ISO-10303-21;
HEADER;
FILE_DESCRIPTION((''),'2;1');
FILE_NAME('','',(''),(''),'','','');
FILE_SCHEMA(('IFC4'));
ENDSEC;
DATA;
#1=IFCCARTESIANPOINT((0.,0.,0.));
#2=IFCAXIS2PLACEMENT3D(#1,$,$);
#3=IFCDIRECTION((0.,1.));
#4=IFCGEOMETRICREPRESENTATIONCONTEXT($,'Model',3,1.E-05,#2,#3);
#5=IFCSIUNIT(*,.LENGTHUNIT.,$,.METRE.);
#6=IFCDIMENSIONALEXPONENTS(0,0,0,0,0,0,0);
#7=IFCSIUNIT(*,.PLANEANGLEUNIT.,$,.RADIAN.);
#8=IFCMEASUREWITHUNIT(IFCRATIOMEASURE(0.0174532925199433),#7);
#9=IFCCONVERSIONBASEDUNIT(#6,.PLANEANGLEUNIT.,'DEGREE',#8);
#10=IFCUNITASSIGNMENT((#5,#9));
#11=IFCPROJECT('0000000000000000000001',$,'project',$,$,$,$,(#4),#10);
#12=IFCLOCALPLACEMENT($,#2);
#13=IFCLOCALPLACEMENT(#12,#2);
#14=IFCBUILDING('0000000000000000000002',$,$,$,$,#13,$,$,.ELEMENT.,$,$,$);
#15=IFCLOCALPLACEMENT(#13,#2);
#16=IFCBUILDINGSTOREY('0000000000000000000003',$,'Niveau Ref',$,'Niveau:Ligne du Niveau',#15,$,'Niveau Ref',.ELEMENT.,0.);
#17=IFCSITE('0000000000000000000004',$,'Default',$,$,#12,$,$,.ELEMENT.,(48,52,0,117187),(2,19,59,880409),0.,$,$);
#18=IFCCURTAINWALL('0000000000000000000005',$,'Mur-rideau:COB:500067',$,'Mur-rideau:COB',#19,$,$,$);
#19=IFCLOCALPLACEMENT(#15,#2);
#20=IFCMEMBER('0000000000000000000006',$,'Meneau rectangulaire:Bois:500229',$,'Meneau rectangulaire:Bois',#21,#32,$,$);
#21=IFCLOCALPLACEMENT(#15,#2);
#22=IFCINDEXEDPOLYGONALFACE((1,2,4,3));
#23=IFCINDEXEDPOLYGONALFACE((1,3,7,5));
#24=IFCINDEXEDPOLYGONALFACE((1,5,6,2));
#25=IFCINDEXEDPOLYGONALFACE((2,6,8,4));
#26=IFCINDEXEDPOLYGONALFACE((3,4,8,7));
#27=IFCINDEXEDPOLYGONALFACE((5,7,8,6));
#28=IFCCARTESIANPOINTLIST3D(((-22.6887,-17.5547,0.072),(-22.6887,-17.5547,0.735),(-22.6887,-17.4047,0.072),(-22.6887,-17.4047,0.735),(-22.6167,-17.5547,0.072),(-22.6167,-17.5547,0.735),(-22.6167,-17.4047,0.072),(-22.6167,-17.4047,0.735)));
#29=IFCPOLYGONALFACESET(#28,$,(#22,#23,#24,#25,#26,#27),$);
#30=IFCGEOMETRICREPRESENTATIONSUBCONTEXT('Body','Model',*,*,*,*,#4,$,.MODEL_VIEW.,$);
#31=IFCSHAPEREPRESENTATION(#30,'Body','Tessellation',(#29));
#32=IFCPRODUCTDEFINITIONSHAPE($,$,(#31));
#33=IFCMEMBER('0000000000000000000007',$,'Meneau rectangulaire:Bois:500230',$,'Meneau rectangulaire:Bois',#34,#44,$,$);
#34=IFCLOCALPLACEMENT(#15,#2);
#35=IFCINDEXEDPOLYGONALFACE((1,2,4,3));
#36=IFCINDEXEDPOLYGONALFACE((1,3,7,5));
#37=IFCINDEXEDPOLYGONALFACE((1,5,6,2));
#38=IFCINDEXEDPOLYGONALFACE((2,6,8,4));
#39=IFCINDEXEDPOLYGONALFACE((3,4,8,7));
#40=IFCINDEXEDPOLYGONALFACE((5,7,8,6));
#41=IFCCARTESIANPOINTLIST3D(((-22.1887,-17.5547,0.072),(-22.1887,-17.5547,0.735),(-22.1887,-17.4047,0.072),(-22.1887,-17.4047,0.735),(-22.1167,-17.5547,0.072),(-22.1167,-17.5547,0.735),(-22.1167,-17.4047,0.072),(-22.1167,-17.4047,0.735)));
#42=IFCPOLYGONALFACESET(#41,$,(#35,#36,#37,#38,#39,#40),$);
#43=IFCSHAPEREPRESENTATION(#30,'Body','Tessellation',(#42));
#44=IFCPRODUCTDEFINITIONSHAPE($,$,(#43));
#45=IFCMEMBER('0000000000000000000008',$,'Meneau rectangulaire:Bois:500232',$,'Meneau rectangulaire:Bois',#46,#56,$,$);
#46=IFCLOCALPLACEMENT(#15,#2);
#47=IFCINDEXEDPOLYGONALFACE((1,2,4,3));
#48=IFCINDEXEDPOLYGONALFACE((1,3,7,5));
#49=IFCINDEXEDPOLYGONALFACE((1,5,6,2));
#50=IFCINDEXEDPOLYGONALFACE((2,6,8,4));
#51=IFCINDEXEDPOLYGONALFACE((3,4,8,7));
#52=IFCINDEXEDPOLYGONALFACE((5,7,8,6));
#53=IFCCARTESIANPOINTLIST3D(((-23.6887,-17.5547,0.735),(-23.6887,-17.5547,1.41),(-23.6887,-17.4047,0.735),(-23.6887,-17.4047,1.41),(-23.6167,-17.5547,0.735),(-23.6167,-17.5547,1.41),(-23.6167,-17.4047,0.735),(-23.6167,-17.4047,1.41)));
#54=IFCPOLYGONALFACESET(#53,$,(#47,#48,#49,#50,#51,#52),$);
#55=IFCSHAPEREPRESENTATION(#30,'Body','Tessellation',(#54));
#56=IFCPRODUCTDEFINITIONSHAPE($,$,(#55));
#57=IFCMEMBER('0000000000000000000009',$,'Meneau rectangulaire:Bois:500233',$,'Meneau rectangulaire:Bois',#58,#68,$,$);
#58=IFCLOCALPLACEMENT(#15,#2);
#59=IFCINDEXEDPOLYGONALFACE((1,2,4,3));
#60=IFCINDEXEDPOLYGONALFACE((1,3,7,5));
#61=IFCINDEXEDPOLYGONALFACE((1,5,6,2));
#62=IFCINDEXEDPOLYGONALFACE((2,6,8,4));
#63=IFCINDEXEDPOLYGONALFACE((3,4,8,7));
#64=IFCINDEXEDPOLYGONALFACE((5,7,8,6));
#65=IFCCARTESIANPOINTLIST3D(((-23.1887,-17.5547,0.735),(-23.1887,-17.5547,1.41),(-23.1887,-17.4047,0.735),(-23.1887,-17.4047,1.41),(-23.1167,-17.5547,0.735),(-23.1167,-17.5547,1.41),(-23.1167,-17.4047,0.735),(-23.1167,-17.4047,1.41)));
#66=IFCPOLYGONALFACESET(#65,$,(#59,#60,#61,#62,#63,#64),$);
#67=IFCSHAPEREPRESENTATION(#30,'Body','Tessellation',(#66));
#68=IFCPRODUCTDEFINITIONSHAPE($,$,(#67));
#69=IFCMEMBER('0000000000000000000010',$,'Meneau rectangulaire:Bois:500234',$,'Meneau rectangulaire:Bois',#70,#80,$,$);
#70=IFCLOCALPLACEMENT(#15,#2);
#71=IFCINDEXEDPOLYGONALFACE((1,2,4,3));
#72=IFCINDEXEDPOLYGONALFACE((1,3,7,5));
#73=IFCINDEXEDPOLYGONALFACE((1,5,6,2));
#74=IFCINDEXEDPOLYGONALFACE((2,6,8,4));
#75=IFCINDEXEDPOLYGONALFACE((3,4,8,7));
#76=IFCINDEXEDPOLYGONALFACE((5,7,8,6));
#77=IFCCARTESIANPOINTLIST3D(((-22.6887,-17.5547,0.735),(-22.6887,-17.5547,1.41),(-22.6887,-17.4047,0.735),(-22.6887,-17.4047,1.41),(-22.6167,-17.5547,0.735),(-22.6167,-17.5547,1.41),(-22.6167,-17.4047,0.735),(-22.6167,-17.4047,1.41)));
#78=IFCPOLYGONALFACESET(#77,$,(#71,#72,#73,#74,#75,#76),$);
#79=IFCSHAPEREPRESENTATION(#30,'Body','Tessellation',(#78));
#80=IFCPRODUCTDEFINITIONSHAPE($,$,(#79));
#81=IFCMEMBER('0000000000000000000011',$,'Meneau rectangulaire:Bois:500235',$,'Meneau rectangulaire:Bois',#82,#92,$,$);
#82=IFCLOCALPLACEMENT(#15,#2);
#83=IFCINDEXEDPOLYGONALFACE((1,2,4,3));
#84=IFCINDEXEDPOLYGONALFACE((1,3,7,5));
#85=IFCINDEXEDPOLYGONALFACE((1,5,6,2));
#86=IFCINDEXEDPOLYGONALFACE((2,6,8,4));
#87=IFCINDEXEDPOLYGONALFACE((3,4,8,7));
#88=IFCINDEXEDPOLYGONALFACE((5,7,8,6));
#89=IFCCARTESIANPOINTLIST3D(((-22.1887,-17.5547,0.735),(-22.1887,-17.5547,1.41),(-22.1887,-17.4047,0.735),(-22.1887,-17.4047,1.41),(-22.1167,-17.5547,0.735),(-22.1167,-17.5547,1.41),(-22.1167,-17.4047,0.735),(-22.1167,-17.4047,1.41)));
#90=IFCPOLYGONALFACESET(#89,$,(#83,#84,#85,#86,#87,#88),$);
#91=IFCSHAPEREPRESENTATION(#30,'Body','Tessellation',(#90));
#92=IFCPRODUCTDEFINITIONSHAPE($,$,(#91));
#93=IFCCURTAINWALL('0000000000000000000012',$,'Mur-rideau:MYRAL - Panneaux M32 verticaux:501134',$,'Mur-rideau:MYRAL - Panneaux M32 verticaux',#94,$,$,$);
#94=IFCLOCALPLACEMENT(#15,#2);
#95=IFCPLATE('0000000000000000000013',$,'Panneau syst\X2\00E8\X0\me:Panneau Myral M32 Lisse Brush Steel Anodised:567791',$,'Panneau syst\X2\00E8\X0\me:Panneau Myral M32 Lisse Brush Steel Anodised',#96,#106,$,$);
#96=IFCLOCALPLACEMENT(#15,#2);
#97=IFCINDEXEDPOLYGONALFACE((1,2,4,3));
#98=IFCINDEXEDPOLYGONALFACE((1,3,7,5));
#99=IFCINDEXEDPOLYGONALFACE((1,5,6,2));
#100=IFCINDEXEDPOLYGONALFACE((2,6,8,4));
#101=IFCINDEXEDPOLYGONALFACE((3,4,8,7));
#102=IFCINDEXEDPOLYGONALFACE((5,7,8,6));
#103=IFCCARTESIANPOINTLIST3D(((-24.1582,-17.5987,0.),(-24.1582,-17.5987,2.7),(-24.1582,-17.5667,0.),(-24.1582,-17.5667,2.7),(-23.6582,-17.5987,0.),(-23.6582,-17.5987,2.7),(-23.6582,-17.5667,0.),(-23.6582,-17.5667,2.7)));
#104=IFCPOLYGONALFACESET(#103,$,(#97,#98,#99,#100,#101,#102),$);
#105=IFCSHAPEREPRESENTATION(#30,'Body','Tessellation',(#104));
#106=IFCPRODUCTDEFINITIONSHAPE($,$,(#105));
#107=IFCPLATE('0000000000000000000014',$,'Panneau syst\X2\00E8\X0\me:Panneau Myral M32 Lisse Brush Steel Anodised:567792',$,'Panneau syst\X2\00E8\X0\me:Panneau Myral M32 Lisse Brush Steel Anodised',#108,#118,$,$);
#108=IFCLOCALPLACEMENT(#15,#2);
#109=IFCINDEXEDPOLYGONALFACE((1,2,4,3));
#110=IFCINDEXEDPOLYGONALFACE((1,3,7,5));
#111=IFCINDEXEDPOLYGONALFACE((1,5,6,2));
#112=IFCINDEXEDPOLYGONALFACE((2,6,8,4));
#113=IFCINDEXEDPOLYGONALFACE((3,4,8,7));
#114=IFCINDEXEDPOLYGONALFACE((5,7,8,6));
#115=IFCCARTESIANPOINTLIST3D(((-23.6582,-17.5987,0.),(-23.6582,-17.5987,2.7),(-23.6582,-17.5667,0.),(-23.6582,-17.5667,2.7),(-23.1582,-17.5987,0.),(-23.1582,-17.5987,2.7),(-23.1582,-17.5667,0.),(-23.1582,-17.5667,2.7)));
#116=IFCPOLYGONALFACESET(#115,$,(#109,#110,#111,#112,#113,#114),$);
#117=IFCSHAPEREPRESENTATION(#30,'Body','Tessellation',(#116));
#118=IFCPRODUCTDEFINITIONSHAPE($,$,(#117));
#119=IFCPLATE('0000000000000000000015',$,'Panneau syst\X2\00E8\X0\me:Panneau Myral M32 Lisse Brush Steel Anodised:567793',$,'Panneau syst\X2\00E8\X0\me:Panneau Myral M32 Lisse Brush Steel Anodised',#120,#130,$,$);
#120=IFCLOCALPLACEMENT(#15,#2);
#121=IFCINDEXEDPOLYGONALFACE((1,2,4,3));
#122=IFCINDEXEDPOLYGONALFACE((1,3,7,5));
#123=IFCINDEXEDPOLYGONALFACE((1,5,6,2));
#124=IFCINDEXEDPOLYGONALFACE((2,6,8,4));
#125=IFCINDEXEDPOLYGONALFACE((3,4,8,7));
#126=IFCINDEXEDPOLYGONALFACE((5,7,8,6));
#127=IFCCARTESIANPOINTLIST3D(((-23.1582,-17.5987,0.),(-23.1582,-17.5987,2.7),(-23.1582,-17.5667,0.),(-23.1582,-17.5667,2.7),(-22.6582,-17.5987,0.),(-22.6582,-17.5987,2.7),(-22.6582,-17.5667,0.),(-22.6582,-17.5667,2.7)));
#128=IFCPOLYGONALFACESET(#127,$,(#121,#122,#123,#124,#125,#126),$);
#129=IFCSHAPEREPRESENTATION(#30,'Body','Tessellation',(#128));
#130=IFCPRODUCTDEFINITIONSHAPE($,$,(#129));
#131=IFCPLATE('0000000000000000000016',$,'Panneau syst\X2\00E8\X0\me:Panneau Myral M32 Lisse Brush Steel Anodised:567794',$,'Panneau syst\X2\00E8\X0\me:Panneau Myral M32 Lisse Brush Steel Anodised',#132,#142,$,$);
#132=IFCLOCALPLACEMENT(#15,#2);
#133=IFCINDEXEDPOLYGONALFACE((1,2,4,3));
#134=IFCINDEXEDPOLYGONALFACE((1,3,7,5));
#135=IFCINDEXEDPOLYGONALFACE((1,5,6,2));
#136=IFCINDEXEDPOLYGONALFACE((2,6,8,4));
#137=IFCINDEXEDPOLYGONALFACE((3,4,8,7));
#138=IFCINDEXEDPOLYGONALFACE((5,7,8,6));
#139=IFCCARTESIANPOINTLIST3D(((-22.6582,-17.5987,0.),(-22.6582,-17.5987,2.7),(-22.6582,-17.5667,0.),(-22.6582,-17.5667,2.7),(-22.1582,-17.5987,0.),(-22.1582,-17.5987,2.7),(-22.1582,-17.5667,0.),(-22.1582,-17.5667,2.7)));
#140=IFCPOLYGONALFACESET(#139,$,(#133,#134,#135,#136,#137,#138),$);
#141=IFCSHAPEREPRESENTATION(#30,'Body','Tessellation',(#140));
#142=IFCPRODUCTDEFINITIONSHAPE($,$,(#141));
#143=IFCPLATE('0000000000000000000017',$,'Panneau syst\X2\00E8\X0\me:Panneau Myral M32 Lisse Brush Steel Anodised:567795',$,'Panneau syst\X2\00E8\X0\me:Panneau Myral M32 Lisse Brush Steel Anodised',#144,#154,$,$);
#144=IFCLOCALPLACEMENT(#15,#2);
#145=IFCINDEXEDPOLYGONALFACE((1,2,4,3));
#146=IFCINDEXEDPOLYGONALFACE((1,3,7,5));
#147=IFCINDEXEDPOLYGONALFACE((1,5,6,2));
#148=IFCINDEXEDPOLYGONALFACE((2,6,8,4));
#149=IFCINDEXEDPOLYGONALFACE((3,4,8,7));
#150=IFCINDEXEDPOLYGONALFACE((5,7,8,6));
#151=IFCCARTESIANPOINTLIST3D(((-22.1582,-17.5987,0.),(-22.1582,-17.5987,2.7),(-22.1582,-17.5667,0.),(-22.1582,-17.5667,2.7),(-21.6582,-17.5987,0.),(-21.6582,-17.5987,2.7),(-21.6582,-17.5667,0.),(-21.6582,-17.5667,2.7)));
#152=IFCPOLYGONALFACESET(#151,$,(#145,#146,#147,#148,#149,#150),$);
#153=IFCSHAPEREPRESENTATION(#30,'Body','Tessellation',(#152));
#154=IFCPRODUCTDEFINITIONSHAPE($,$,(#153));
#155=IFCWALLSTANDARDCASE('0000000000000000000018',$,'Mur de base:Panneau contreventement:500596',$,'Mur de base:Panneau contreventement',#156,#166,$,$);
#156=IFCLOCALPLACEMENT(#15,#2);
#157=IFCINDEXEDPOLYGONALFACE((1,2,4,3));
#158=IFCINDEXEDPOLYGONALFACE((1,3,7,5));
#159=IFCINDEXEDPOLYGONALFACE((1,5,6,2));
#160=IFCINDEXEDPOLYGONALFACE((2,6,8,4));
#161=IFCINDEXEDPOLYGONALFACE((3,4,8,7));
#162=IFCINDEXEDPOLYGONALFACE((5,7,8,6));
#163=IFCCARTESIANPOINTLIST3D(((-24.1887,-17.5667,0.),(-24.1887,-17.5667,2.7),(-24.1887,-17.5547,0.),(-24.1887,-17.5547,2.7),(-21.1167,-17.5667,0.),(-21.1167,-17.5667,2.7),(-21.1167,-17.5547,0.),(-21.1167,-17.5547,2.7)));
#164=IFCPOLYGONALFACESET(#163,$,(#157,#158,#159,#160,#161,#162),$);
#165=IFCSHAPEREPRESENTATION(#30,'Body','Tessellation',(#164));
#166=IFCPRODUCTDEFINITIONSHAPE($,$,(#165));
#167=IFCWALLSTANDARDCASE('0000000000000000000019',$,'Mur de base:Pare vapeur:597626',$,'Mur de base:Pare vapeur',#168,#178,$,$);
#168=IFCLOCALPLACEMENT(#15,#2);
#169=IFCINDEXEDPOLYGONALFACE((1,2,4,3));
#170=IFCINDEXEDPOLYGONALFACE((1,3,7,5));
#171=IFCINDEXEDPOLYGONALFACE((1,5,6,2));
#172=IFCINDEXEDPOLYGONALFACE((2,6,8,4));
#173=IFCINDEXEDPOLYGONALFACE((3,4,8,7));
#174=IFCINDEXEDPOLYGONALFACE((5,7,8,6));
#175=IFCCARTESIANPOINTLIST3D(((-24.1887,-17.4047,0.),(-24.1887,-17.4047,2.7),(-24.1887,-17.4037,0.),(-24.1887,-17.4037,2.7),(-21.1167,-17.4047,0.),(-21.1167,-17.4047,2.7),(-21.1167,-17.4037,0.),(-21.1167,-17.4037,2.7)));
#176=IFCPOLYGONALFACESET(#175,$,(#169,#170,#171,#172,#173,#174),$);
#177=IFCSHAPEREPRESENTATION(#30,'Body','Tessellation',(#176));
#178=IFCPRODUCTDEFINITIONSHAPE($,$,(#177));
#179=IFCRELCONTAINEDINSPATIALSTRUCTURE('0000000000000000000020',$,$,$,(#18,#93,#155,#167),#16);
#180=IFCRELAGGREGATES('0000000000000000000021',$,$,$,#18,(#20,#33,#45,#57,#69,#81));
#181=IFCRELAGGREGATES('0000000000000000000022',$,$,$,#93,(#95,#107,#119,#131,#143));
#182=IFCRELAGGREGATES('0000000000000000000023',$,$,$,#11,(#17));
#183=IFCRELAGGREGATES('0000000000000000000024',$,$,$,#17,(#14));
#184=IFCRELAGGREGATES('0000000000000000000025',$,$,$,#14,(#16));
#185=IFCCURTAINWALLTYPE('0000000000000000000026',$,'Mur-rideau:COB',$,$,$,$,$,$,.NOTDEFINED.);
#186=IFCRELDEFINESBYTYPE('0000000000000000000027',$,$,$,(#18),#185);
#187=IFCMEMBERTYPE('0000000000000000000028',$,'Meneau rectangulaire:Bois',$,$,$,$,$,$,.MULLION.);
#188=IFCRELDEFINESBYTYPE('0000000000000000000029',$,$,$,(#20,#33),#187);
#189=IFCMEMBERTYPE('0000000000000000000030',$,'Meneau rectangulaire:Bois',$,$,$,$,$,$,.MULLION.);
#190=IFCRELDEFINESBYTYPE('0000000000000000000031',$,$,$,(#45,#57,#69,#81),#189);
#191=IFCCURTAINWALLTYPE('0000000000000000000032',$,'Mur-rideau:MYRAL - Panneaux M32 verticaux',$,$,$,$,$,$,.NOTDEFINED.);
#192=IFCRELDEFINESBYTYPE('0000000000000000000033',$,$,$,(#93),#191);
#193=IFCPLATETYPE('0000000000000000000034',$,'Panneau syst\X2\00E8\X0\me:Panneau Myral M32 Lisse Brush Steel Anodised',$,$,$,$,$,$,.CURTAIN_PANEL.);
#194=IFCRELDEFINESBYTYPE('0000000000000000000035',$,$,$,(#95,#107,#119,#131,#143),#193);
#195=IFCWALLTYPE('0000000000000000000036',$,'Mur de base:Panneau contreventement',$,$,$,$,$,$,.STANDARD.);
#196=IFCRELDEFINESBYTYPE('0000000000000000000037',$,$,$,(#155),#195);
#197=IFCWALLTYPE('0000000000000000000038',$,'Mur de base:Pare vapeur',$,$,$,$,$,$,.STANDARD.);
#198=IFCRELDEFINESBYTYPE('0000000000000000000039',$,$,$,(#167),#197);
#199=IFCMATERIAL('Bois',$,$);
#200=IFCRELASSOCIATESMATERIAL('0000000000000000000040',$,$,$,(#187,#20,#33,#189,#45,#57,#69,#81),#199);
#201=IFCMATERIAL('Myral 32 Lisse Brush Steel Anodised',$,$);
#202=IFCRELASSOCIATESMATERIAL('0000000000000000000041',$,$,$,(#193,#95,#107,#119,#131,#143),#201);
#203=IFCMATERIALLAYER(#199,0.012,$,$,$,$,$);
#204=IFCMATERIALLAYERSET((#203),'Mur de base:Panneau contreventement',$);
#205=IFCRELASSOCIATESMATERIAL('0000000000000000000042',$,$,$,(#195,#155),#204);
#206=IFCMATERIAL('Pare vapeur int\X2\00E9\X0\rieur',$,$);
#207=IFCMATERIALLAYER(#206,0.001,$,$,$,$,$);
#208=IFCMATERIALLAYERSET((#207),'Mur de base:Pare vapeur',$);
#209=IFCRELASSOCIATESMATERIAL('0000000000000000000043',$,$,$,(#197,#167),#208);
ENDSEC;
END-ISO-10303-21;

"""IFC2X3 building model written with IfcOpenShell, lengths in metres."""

from ifc_helpers import new_model, entity, si_unit, converted_unit, direction, frame, frame_2d, origin, origin_2d_with_axis, place, context, subcontext, project, spatial, rectangle, extrude, source, transform, mapped, material, layer, layer_set, layer_usage, type_object, type_shapes, element, aggregate, save


model = new_model("IFC2X3")

# Units and contexts
model_context = context("Model", 3, precision=1e-05, world=origin(), true_north=direction((0.0, 1.0)))
body_context = subcontext(model_context, "Body", "Model", "MODEL_VIEW")
ifc_project = project(units=[si_unit("LENGTHUNIT", "METRE"), converted_unit("PLANEANGLEUNIT", "DEGREE", entity("IfcRatioMeasure", 0.0174532925199433), si_unit("PLANEANGLEUNIT", "RADIAN"), dimensions=[0, 0, 0, 0, 0, 0, 0])], contexts=[model_context])

# Site, building, storey
site_placement = place(None, origin())
site = spatial("IfcSite", under=ifc_project, at=site_placement, Name="Default", CompositionType="ELEMENT", RefLatitude=(48, 52, 0, 117187), RefLongitude=(2, 19, 59, 880409), RefElevation=0.0)
building_placement = place(site_placement, origin())
building = spatial("IfcBuilding", under=site, at=building_placement, CompositionType="ELEMENT")
storey_placement = place(building_placement, origin())
storey = spatial("IfcBuildingStorey", under=building, at=storey_placement, Name="Niveau Ref", ObjectType="Niveau:Ligne du Niveau", LongName="Niveau Ref", CompositionType="ELEMENT", Elevation=0.0)

# Curtain wall, members
curtain_wall_type_1 = type_object("IfcCurtainWallType", Name="Mur-rideau:COB", PredefinedType="NOTDEFINED")
curtain_wall_1_placement = place(storey_placement, origin())
curtain_wall_1 = element("IfcCurtainWall", 1, at=curtain_wall_1_placement, inside=storey, type_object=curtain_wall_type_1, Name="Mur-rideau:COB:500067", ObjectType="Mur-rideau:COB")
ifc_material_1 = material(Name="Bois")
member_type_1 = type_object("IfcMemberType", Name="Meneau rectangulaire:Bois", PredefinedType="MULLION", material=ifc_material_1)
shared_shape_1 = source(origin(), body_context, "Body", "SweptSolid", [
    extrude(rectangle(XDim=0.15, YDim=0.072, at=origin_2d_with_axis()), frame((-0.024, 0.0, -0.663), z_axis=(0.0, 0.0, 1.0), x_axis=(0.0, -1.0, 0.0)), (0.0, 0.0, 1.0), 0.663),
])
type_shapes(member_type_1, [shared_shape_1])
member_1_placement = place(storey_placement, frame((-22.6287, -17.4797, 0.072), z_axis=(0.0, 0.0, -1.0), x_axis=(1.0, 0.0, 0.0)))
member_1 = element("IfcMember", 2, at=member_1_placement, type_object=member_type_1, material=ifc_material_1, Name="Meneau rectangulaire:Bois:500229", ObjectType="Meneau rectangulaire:Bois", context=body_context, shape_type="MappedRepresentation", body=[
    mapped(shared_shape_1, transform((0.0, 0.0, 0.0), scale=1.0)),
])
member_2_placement = place(storey_placement, frame((-22.1287, -17.4797, 0.072), z_axis=(0.0, 0.0, -1.0), x_axis=(1.0, 0.0, 0.0)))
member_2 = element("IfcMember", 3, at=member_2_placement, type_object=member_type_1, material=ifc_material_1, Name="Meneau rectangulaire:Bois:500230", ObjectType="Meneau rectangulaire:Bois", context=body_context, shape_type="MappedRepresentation", body=[
    mapped(shared_shape_1, transform((0.0, 0.0, 0.0), scale=1.0)),
])
member_type_2 = type_object("IfcMemberType", Name="Meneau rectangulaire:Bois", PredefinedType="MULLION", material=ifc_material_1)
shared_shape_2 = source(origin(), body_context, "Body", "SweptSolid", [
    extrude(rectangle(XDim=0.15, YDim=0.072, at=origin_2d_with_axis()), frame((-0.024, 0.0, -0.675), z_axis=(0.0, 0.0, 1.0), x_axis=(0.0, -1.0, 0.0)), (0.0, 0.0, 1.0), 0.675),
])
type_shapes(member_type_2, [shared_shape_2])
member_3_placement = place(storey_placement, frame((-23.6287, -17.4797, 0.735), z_axis=(0.0, 0.0, -1.0), x_axis=(1.0, 0.0, 0.0)))
member_3 = element("IfcMember", 4, at=member_3_placement, type_object=member_type_2, material=ifc_material_1, Name="Meneau rectangulaire:Bois:500232", ObjectType="Meneau rectangulaire:Bois", context=body_context, shape_type="MappedRepresentation", body=[
    mapped(shared_shape_2, transform((0.0, 0.0, 0.0), scale=1.0)),
])
member_4_placement = place(storey_placement, frame((-23.1287, -17.4797, 0.735), z_axis=(0.0, 0.0, -1.0), x_axis=(1.0, 0.0, 0.0)))
member_4 = element("IfcMember", 5, at=member_4_placement, type_object=member_type_2, material=ifc_material_1, Name="Meneau rectangulaire:Bois:500233", ObjectType="Meneau rectangulaire:Bois", context=body_context, shape_type="MappedRepresentation", body=[
    mapped(shared_shape_2, transform((0.0, 0.0, 0.0), scale=1.0)),
])
member_5_placement = place(storey_placement, frame((-22.6287, -17.4797, 0.735), z_axis=(0.0, 0.0, -1.0), x_axis=(1.0, 0.0, 0.0)))
member_5 = element("IfcMember", 6, at=member_5_placement, type_object=member_type_2, material=ifc_material_1, Name="Meneau rectangulaire:Bois:500234", ObjectType="Meneau rectangulaire:Bois", context=body_context, shape_type="MappedRepresentation", body=[
    mapped(shared_shape_2, transform((0.0, 0.0, 0.0), scale=1.0)),
])
member_6_placement = place(storey_placement, frame((-22.1287, -17.4797, 0.735), z_axis=(0.0, 0.0, -1.0), x_axis=(1.0, 0.0, 0.0)))
member_6 = element("IfcMember", 7, at=member_6_placement, type_object=member_type_2, material=ifc_material_1, Name="Meneau rectangulaire:Bois:500235", ObjectType="Meneau rectangulaire:Bois", context=body_context, shape_type="MappedRepresentation", body=[
    mapped(shared_shape_2, transform((0.0, 0.0, 0.0), scale=1.0)),
])
aggregate(curtain_wall_1, [member_1, member_2, member_3, member_4, member_5, member_6])

# Curtain wall, plates
curtain_wall_type_2 = type_object("IfcCurtainWallType", Name="Mur-rideau:MYRAL - Panneaux M32 verticaux", PredefinedType="NOTDEFINED")
curtain_wall_2_placement = place(storey_placement, origin())
curtain_wall_2 = element("IfcCurtainWall", 8, at=curtain_wall_2_placement, inside=storey, type_object=curtain_wall_type_2, Name="Mur-rideau:MYRAL - Panneaux M32 verticaux:501134", ObjectType="Mur-rideau:MYRAL - Panneaux M32 verticaux")
ifc_material_2 = material(Name="Myral 32 Lisse Brush Steel Anodised")
plate_type = type_object("IfcPlateType", Name="Panneau système:Panneau Myral M32 Lisse Brush Steel Anodised", PredefinedType="CURTAIN_PANEL", material=ifc_material_2)
shared_shape_3 = source(origin(), body_context, "Body", "SweptSolid", [
    extrude(rectangle(XDim=0.032, YDim=0.5, at=origin_2d_with_axis()), frame((0.0, -0.016, 0.0), z_axis=(0.0, 0.0, 1.0), x_axis=(0.0, 1.0, 0.0)), (0.0, 0.0, 1.0), 2.7),
])
type_shapes(plate_type, [shared_shape_3])
plate_1_placement = place(curtain_wall_2_placement, frame((-23.9082, -17.5667, 0.0)))
plate_1 = element("IfcPlate", 9, at=plate_1_placement, type_object=plate_type, material=ifc_material_2, Name="Panneau système:Panneau Myral M32 Lisse Brush Steel Anodised:567791", ObjectType="Panneau système:Panneau Myral M32 Lisse Brush Steel Anodised", context=body_context, shape_type="MappedRepresentation", body=[
    mapped(shared_shape_3, transform((0.0, 0.0, 0.0), scale=1.0)),
])
plate_2_placement = place(curtain_wall_2_placement, frame((-23.4082, -17.5667, 0.0)))
plate_2 = element("IfcPlate", 10, at=plate_2_placement, type_object=plate_type, material=ifc_material_2, Name="Panneau système:Panneau Myral M32 Lisse Brush Steel Anodised:567792", ObjectType="Panneau système:Panneau Myral M32 Lisse Brush Steel Anodised", context=body_context, shape_type="MappedRepresentation", body=[
    mapped(shared_shape_3, transform((0.0, 0.0, 0.0), scale=1.0)),
])
plate_3_placement = place(curtain_wall_2_placement, frame((-22.9082, -17.5667, 0.0)))
plate_3 = element("IfcPlate", 11, at=plate_3_placement, type_object=plate_type, material=ifc_material_2, Name="Panneau système:Panneau Myral M32 Lisse Brush Steel Anodised:567793", ObjectType="Panneau système:Panneau Myral M32 Lisse Brush Steel Anodised", context=body_context, shape_type="MappedRepresentation", body=[
    mapped(shared_shape_3, transform((0.0, 0.0, 0.0), scale=1.0)),
])
plate_4_placement = place(curtain_wall_2_placement, frame((-22.4082, -17.5667, 0.0)))
plate_4 = element("IfcPlate", 12, at=plate_4_placement, type_object=plate_type, material=ifc_material_2, Name="Panneau système:Panneau Myral M32 Lisse Brush Steel Anodised:567794", ObjectType="Panneau système:Panneau Myral M32 Lisse Brush Steel Anodised", context=body_context, shape_type="MappedRepresentation", body=[
    mapped(shared_shape_3, transform((0.0, 0.0, 0.0), scale=1.0)),
])
plate_5_placement = place(curtain_wall_2_placement, frame((-21.9082, -17.5667, 0.0)))
plate_5 = element("IfcPlate", 13, at=plate_5_placement, type_object=plate_type, material=ifc_material_2, Name="Panneau système:Panneau Myral M32 Lisse Brush Steel Anodised:567795", ObjectType="Panneau système:Panneau Myral M32 Lisse Brush Steel Anodised", context=body_context, shape_type="MappedRepresentation", body=[
    mapped(shared_shape_3, transform((0.0, 0.0, 0.0), scale=1.0)),
])
aggregate(curtain_wall_2, [plate_1, plate_2, plate_3, plate_4, plate_5])

# Walls
ifc_layer_1 = layer(ifc_material_1, 0.012)
ifc_layer_set_1 = layer_set([ifc_layer_1], Name="Mur de base:Panneau contreventement")
ifc_layer_usage_1 = layer_usage(ifc_layer_set_1, "AXIS2", "NEGATIVE", 0.006)
wall_type_1 = type_object("IfcWallType", Name="Mur de base:Panneau contreventement", PredefinedType="STANDARD", material=ifc_layer_set_1)
wall_1_placement = place(storey_placement, frame((-24.1887, -17.5607, 0.0)))
element("IfcWallStandardCase", 14, at=wall_1_placement, inside=storey, type_object=wall_type_1, material=ifc_layer_usage_1, Name="Mur de base:Panneau contreventement:500596", ObjectType="Mur de base:Panneau contreventement", context=body_context, shape_type="SweptSolid", body=[
    extrude(rectangle(XDim=3.072, YDim=0.012, at=frame_2d((1.536, 0.0), x_axis=(-1.0, 0.0))), origin(), (0.0, 0.0, 1.0), 2.7),
])
ifc_material_3 = material(Name="Pare vapeur intérieur")
ifc_layer_2 = layer(ifc_material_3, 0.001)
ifc_layer_set_2 = layer_set([ifc_layer_2], Name="Mur de base:Pare vapeur")
ifc_layer_usage_2 = layer_usage(ifc_layer_set_2, "AXIS2", "NEGATIVE", 0.0005)
wall_type_2 = type_object("IfcWallType", Name="Mur de base:Pare vapeur", PredefinedType="STANDARD", material=ifc_layer_set_2)
wall_2_placement = place(storey_placement, frame((-24.1887, -17.4042, 0.0)))
element("IfcWallStandardCase", 15, at=wall_2_placement, inside=storey, type_object=wall_type_2, material=ifc_layer_usage_2, Name="Mur de base:Pare vapeur:597626", ObjectType="Mur de base:Pare vapeur", context=body_context, shape_type="SweptSolid", body=[
    extrude(rectangle(XDim=3.072, YDim=0.001, at=frame_2d((1.536, 0.0), x_axis=(-1.0, 0.0))), origin(), (0.0, 0.0, 1.0), 2.7),
])

save(model, "model.ifc")
